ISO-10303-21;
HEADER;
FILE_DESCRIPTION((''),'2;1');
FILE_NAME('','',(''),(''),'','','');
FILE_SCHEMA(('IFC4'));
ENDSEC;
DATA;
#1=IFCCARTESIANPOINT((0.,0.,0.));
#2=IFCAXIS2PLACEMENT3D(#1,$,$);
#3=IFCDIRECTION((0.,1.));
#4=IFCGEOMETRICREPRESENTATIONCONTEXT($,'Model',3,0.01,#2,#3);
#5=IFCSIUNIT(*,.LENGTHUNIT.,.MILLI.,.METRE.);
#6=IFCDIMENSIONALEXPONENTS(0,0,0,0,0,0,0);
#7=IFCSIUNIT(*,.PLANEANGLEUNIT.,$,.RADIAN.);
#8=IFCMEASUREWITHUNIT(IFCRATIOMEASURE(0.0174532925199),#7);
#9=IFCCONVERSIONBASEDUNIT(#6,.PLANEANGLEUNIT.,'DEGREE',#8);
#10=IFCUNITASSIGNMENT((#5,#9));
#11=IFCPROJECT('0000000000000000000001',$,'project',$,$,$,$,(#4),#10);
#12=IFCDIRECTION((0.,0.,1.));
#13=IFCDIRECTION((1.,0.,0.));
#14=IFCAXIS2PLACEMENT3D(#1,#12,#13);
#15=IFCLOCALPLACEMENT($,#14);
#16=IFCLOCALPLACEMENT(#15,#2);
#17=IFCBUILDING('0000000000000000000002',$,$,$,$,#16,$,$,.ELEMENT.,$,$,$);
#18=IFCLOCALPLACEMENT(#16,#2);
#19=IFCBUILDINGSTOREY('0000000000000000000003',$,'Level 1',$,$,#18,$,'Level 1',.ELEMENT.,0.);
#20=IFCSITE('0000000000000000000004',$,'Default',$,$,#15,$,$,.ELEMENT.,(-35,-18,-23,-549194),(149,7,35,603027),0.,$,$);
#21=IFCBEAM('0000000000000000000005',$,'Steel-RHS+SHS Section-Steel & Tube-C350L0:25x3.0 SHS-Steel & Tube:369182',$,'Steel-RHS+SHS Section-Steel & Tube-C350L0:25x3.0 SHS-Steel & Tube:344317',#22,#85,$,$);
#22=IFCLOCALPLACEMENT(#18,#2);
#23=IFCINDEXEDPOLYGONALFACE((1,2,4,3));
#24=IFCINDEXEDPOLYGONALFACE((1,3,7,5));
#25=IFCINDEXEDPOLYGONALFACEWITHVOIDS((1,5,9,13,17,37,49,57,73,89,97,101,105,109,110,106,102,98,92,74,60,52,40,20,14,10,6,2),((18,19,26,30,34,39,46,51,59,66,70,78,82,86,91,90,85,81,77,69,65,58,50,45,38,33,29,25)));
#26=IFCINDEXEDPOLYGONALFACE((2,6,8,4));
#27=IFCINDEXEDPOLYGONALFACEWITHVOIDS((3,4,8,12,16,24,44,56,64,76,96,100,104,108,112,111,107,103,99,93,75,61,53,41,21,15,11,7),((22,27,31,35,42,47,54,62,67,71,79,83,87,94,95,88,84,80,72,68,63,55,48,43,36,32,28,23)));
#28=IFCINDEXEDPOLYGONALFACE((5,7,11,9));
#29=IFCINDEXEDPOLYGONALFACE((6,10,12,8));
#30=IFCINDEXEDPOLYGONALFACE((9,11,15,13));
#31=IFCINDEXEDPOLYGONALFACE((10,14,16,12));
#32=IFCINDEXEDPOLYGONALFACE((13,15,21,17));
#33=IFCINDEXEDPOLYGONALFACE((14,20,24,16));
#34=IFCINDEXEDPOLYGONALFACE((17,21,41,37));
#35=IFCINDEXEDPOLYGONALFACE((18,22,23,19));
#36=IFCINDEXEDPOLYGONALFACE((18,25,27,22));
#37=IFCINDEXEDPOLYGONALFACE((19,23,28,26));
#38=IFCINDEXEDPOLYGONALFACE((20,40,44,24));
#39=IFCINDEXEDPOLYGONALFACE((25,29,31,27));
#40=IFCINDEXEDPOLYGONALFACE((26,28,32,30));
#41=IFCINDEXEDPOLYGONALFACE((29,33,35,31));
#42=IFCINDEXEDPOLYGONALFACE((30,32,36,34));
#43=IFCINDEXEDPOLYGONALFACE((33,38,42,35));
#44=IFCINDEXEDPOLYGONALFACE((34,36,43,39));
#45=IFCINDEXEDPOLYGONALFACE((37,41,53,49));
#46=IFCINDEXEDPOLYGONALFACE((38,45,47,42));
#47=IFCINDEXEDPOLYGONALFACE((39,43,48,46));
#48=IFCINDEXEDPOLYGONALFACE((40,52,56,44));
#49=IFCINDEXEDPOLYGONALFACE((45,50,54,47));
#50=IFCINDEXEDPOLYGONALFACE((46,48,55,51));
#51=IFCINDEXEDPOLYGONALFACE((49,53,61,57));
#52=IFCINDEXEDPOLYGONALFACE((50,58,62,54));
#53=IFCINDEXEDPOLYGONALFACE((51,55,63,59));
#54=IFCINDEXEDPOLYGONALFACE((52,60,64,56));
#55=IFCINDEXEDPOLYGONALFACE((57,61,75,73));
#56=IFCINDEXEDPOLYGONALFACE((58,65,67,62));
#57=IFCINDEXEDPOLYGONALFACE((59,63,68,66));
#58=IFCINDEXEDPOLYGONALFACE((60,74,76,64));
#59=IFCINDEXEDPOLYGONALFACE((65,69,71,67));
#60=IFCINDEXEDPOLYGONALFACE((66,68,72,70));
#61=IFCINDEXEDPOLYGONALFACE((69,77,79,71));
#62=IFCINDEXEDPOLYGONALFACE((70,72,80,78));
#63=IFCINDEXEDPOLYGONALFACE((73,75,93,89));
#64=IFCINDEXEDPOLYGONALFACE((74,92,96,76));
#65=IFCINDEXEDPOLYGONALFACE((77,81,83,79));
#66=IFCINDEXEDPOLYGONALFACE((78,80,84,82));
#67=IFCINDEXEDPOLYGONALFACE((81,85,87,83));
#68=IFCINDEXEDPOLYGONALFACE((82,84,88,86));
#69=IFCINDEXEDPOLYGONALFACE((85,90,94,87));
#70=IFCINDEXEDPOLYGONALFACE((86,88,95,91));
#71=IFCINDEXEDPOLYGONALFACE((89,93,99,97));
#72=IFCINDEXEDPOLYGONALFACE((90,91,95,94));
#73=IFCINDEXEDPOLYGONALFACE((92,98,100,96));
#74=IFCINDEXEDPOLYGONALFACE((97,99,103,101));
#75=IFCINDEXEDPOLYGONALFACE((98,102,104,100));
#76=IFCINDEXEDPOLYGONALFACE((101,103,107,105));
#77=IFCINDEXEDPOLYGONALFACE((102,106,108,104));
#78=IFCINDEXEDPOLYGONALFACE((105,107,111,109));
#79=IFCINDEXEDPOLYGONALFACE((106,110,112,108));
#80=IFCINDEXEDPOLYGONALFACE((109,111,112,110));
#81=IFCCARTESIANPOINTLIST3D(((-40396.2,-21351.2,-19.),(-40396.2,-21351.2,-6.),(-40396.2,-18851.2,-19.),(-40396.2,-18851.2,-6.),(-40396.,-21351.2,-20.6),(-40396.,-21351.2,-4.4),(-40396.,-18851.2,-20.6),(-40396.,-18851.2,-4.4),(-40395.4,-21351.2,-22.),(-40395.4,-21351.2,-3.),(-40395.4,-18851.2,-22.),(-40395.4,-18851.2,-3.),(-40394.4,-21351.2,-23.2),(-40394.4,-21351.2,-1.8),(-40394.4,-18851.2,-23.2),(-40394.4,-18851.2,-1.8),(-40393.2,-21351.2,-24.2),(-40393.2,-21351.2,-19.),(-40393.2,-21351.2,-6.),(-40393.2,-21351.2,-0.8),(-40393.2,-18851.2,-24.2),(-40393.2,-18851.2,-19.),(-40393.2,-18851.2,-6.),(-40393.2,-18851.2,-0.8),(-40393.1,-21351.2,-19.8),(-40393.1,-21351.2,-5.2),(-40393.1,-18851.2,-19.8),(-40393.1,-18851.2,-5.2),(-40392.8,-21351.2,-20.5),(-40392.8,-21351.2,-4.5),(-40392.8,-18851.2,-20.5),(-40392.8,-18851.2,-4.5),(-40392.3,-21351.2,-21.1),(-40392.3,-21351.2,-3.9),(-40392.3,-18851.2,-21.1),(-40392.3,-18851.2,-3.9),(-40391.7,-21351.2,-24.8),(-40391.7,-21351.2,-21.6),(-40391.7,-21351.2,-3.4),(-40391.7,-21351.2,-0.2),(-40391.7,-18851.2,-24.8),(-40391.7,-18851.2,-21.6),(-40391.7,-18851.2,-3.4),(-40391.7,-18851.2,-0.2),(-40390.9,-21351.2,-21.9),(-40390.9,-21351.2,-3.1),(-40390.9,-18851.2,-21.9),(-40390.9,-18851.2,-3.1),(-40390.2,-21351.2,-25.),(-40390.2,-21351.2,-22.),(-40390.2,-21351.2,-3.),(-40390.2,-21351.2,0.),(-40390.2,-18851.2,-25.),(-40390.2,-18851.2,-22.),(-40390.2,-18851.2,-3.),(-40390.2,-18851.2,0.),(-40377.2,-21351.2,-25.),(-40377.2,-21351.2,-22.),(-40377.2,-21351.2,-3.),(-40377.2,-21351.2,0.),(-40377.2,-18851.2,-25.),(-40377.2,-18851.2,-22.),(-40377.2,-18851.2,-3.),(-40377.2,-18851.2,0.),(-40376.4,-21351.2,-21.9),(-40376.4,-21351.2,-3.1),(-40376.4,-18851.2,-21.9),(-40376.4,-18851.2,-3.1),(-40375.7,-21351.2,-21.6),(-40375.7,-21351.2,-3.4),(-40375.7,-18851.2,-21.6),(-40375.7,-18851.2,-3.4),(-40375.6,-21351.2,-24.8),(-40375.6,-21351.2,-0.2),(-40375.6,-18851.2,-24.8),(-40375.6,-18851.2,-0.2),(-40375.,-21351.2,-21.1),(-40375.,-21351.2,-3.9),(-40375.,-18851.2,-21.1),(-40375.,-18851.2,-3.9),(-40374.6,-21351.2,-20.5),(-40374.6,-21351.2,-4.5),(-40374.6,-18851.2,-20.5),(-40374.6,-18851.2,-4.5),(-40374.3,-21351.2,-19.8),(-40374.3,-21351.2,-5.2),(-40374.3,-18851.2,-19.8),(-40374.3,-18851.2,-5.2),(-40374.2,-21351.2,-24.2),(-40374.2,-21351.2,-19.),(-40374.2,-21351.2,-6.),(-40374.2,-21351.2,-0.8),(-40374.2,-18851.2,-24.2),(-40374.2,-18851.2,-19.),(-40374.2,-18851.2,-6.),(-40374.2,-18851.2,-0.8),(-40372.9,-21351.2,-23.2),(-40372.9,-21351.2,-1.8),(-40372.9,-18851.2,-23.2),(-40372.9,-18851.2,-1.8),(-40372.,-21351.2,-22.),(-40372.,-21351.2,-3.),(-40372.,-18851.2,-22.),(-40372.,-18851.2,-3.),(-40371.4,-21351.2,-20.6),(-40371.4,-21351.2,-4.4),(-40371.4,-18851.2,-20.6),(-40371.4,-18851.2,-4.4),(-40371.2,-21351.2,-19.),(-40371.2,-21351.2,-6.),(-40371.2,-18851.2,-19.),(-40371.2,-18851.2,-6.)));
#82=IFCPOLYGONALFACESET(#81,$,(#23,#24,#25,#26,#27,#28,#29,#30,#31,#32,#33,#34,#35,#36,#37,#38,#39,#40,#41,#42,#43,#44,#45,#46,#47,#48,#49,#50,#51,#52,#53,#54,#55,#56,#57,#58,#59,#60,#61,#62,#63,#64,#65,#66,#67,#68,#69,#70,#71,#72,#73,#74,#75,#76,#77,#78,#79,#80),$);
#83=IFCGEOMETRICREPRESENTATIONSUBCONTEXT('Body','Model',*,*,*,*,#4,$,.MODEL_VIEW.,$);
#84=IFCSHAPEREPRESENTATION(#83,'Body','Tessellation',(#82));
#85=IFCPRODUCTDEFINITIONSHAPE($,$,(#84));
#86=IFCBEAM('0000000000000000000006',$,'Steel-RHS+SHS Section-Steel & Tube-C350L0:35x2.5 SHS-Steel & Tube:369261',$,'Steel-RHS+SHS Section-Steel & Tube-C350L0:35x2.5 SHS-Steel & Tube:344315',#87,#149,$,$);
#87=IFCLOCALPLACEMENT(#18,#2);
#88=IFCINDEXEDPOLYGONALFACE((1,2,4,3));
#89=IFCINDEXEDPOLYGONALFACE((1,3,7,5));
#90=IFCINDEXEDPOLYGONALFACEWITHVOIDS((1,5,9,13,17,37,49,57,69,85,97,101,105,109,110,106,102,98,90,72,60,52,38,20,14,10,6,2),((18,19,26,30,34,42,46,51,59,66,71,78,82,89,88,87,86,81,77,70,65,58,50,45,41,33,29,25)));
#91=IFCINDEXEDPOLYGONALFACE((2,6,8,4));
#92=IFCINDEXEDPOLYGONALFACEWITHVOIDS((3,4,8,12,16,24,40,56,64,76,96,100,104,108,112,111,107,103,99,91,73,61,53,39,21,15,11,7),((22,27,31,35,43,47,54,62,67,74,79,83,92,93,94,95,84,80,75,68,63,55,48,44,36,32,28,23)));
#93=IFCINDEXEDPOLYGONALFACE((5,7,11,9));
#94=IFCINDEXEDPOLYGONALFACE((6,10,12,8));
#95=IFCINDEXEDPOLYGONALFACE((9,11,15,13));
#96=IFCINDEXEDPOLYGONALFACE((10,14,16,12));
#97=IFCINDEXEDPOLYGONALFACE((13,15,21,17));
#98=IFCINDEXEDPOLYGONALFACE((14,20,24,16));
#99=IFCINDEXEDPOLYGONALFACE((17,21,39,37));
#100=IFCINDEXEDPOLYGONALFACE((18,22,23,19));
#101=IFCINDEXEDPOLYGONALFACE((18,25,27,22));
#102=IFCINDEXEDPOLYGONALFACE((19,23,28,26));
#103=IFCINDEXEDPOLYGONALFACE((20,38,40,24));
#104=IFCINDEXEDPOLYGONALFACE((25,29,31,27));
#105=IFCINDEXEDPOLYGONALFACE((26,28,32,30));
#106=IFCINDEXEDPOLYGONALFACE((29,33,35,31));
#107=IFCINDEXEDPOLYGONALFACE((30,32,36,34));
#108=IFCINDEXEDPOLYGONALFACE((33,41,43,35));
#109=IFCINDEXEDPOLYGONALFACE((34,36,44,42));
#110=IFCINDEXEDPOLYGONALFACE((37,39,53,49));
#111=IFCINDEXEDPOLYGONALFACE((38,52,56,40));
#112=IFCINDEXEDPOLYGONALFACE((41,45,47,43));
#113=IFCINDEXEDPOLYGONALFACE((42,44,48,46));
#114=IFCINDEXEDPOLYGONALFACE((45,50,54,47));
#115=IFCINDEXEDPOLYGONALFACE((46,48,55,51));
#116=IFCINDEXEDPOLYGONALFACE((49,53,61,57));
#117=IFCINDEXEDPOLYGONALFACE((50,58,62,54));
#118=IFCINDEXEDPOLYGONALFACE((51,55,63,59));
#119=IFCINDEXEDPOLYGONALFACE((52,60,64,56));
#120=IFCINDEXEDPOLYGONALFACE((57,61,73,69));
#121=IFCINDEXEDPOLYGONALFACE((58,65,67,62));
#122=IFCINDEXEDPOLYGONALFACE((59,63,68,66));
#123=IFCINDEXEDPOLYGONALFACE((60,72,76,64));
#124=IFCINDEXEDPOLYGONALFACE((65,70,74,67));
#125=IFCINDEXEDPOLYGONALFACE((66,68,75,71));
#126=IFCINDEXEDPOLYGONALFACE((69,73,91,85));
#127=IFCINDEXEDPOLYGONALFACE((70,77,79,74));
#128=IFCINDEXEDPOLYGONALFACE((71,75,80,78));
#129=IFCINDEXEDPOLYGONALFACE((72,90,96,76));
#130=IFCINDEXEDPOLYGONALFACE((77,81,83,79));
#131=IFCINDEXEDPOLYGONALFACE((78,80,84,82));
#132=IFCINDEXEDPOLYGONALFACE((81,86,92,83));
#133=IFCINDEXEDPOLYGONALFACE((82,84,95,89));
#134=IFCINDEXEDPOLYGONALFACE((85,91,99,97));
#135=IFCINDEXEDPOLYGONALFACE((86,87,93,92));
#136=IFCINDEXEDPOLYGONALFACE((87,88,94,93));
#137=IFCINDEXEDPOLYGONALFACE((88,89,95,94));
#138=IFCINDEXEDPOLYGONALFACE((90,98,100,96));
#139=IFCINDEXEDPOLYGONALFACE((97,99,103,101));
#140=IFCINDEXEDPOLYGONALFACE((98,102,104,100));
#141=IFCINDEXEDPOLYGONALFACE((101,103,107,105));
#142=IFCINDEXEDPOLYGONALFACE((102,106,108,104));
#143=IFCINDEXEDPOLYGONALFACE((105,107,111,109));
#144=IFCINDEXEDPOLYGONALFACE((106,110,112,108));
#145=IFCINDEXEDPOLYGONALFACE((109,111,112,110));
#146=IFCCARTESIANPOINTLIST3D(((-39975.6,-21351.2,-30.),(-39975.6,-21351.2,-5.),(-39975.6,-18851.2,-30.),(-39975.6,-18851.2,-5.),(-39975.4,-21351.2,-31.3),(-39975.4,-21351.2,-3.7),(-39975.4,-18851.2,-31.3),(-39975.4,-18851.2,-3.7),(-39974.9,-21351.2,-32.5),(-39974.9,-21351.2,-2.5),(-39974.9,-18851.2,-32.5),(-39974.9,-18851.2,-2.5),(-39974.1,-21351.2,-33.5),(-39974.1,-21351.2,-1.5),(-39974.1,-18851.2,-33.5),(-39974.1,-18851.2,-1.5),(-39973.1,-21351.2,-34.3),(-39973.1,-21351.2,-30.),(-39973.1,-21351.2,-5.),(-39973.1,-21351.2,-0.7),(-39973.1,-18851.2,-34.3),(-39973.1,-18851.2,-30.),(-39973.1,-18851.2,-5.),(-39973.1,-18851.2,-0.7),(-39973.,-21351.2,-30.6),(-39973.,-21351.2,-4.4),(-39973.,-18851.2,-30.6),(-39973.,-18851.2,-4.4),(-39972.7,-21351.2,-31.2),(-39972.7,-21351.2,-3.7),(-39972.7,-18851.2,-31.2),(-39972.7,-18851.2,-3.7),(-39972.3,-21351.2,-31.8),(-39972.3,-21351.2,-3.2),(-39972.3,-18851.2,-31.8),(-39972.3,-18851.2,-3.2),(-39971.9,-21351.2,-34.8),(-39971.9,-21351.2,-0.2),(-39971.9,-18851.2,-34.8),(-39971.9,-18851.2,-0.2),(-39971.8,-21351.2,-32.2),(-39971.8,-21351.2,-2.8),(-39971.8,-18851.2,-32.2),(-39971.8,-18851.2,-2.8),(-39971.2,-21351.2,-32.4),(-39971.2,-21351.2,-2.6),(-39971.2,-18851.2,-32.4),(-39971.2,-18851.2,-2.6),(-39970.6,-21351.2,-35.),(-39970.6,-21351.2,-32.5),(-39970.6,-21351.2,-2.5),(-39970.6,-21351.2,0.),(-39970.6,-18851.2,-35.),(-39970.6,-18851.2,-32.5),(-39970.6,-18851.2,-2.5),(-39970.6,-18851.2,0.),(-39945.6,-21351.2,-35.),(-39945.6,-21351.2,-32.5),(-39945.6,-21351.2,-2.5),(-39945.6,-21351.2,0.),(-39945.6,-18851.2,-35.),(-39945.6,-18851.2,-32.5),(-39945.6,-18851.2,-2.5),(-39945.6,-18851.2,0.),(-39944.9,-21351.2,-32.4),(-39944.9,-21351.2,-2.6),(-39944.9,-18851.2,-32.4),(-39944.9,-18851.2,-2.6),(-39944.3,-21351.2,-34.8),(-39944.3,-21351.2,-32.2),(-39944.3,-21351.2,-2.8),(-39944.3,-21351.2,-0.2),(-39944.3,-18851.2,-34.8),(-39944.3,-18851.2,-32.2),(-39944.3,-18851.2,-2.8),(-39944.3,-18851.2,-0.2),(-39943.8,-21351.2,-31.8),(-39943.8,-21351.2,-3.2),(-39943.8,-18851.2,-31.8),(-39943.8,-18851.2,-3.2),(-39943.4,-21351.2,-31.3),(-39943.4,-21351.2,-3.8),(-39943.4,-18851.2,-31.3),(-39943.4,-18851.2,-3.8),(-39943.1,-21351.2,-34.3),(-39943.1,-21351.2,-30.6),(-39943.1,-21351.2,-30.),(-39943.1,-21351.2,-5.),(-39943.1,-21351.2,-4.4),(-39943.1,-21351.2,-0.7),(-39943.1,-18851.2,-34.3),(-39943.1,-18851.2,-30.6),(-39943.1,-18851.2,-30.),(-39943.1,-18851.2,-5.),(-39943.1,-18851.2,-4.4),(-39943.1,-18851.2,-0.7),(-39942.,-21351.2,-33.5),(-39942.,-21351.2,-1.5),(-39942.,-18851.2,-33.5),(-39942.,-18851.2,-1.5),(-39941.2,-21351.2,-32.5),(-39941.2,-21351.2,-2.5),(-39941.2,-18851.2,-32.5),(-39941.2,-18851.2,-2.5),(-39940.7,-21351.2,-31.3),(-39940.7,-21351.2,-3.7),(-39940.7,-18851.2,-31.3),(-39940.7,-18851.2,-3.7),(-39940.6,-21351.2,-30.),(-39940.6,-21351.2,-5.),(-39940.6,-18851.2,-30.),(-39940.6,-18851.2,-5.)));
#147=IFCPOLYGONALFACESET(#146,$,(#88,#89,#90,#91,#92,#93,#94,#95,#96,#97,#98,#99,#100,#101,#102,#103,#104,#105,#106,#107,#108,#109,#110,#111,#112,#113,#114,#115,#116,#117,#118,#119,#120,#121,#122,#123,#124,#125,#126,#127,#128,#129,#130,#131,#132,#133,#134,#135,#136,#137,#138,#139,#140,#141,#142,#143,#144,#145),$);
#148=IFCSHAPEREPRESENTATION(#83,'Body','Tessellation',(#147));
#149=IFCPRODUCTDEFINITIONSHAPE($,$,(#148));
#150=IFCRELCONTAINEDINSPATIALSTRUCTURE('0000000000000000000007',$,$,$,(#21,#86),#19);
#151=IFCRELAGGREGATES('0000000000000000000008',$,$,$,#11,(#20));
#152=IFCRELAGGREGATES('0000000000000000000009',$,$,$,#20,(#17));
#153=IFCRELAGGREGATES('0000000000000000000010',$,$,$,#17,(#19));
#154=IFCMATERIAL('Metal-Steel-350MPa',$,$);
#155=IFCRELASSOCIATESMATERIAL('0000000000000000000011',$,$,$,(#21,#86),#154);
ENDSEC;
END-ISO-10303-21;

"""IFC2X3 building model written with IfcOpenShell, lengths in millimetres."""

from ifc_helpers import new_model, entity, si_unit, converted_unit, direction, frame, frame_2d, origin, origin_with_axes, place, context, subcontext, project, spatial, polyline, circle_curve, parameter, trimmed, segment, composite_curve, outline, extrude, material, element, save


model = new_model("IFC2X3")

# Units and contexts
model_context = context("Model", 3, precision=0.01, world=origin(), true_north=direction((0.0, 1.0)))
body_context = subcontext(model_context, "Body", "Model", "MODEL_VIEW")
ifc_project = project(units=[si_unit("LENGTHUNIT", "METRE", prefix="MILLI"), converted_unit("PLANEANGLEUNIT", "DEGREE", entity("IfcRatioMeasure", 0.0174532925199), si_unit("PLANEANGLEUNIT", "RADIAN"), dimensions=[0, 0, 0, 0, 0, 0, 0])], contexts=[model_context])

# Site, building, storey
site_placement = place(None, origin_with_axes())
site = spatial("IfcSite", under=ifc_project, at=site_placement, Name="Default", CompositionType="ELEMENT", RefLatitude=(-35, -18, -23, -549194), RefLongitude=(149, 7, 35, 603027), RefElevation=0.0)
building_placement = place(site_placement, origin())
building = spatial("IfcBuilding", under=site, at=building_placement, CompositionType="ELEMENT")
storey_placement = place(building_placement, origin())
storey = spatial("IfcBuildingStorey", under=building, at=storey_placement, Name="Level 1", LongName="Level 1", CompositionType="ELEMENT", Elevation=0.0)

# Beams
ifc_material = material(Name="Metal-Steel-350MPa")
beam_1_placement = place(storey_placement, frame((-40383.7, -18851.2, 0.0), z_axis=(0.0, 0.0, 1.0), x_axis=(0.0, -1.0, 0.0)))
element("IfcBeam", 1, at=beam_1_placement, inside=storey, material=ifc_material, Name="Steel-RHS+SHS Section-Steel & Tube-C350L0:25x3.0 SHS-Steel & Tube:369182", ObjectType="Steel-RHS+SHS Section-Steel & Tube-C350L0:25x3.0 SHS-Steel & Tube:344317", context=body_context, shape_type="SweptSolid", body=[
    extrude(outline(composite_curve([segment(trimmed(circle_curve(frame_2d((-6.5, -6.5), x_axis=(1.0, 0.0)), 6.0), [parameter(180.0)], [parameter(270.0)], True, "PARAMETER"), True, "CONTINUOUS"), segment(polyline([(-6.5, -12.5), (6.5, -12.5)]), True, "CONTINUOUS"), segment(trimmed(circle_curve(frame_2d((6.5, -6.5), x_axis=(1.0, 0.0)), 6.0), [parameter(270.0)], [parameter(0.0)], True, "PARAMETER"), True, "CONTINUOUS"), segment(polyline([(12.5, -6.5), (12.5, 6.5)]), True, "CONTINUOUS"), segment(trimmed(circle_curve(frame_2d((6.5, 6.5), x_axis=(1.0, 0.0)), 6.0), [parameter(0.0)], [parameter(90.0)], True, "PARAMETER"), True, "CONTINUOUS"), segment(polyline([(6.5, 12.5), (-6.5, 12.5)]), True, "CONTINUOUS"), segment(trimmed(circle_curve(frame_2d((-6.5, 6.5), x_axis=(1.0, 0.0)), 6.0), [parameter(90.0)], [parameter(180.0)], True, "PARAMETER"), True, "CONTINUOUS"), segment(polyline([(-12.5, 6.5), (-12.5, -6.5)]), True, "CONTINUOUS")], self_intersect=False), holes=[composite_curve([segment(polyline([(6.5, -9.5), (-6.5, -9.5)]), True, "CONTINUOUS"), segment(trimmed(circle_curve(frame_2d((-6.5, -6.5), x_axis=(1.0, 0.0)), 3.0), [parameter(180.0)], [parameter(270.0)], True, "PARAMETER"), False, "CONTINUOUS"), segment(polyline([(-9.5, -6.5), (-9.5, 6.5)]), True, "CONTINUOUS"), segment(trimmed(circle_curve(frame_2d((-6.5, 6.5), x_axis=(1.0, 0.0)), 3.0), [parameter(90.0)], [parameter(180.0)], True, "PARAMETER"), False, "CONTINUOUS"), segment(polyline([(-6.5, 9.5), (6.5, 9.5)]), True, "CONTINUOUS"), segment(trimmed(circle_curve(frame_2d((6.5, 6.5), x_axis=(1.0, 0.0)), 3.0), [parameter(360.0)], [parameter(90.0)], True, "PARAMETER"), False, "CONTINUOUS"), segment(polyline([(9.5, 6.5), (9.5, -6.5)]), True, "CONTINUOUS"), segment(trimmed(circle_curve(frame_2d((6.5, -6.5), x_axis=(1.0, 0.0)), 3.0), [parameter(270.0)], [parameter(0.0)], True, "PARAMETER"), False, "CONTINUOUS")], self_intersect=False)]), frame((0.0, 0.0, -12.5), z_axis=(1.0, 0.0, 0.0), x_axis=(0.0, -1.0, 0.0)), (0.0, 0.0, 1.0), 2500.0),
])
beam_2_placement = place(storey_placement, frame((-39958.1, -18851.2, 0.0), z_axis=(0.0, 0.0, 1.0), x_axis=(0.0, -1.0, 0.0)))
element("IfcBeam", 2, at=beam_2_placement, inside=storey, material=ifc_material, Name="Steel-RHS+SHS Section-Steel & Tube-C350L0:35x2.5 SHS-Steel & Tube:369261", ObjectType="Steel-RHS+SHS Section-Steel & Tube-C350L0:35x2.5 SHS-Steel & Tube:344315", context=body_context, shape_type="SweptSolid", body=[
    extrude(outline(composite_curve([segment(trimmed(circle_curve(frame_2d((-12.5, -12.5), x_axis=(1.0, 0.0)), 5.0), [parameter(180.0)], [parameter(270.0)], True, "PARAMETER"), True, "CONTINUOUS"), segment(polyline([(-12.5, -17.5), (12.5, -17.5)]), True, "CONTINUOUS"), segment(trimmed(circle_curve(frame_2d((12.5, -12.5), x_axis=(1.0, 0.0)), 5.0), [parameter(270.0)], [parameter(0.0)], True, "PARAMETER"), True, "CONTINUOUS"), segment(polyline([(17.5, -12.5), (17.5, 12.5)]), True, "CONTINUOUS"), segment(trimmed(circle_curve(frame_2d((12.5, 12.5), x_axis=(1.0, 0.0)), 5.0), [parameter(0.0)], [parameter(90.0)], True, "PARAMETER"), True, "CONTINUOUS"), segment(polyline([(12.5, 17.5), (-12.5, 17.5)]), True, "CONTINUOUS"), segment(trimmed(circle_curve(frame_2d((-12.5, 12.5), x_axis=(1.0, 0.0)), 5.0), [parameter(90.0)], [parameter(180.0)], True, "PARAMETER"), True, "CONTINUOUS"), segment(polyline([(-17.5, 12.5), (-17.5, -12.5)]), True, "CONTINUOUS")], self_intersect=False), holes=[composite_curve([segment(polyline([(12.5, -15.0), (-12.5, -15.0)]), True, "CONTINUOUS"), segment(trimmed(circle_curve(frame_2d((-12.5, -12.5), x_axis=(1.0, 0.0)), 2.5), [parameter(180.0)], [parameter(270.0)], True, "PARAMETER"), False, "CONTINUOUS"), segment(polyline([(-15.0, -12.5), (-15.0, 12.5)]), True, "CONTINUOUS"), segment(trimmed(circle_curve(frame_2d((-12.5, 12.5), x_axis=(1.0, 0.0)), 2.5), [parameter(90.0)], [parameter(180.0)], True, "PARAMETER"), False, "CONTINUOUS"), segment(polyline([(-12.5, 15.0), (12.5, 15.0)]), True, "CONTINUOUS"), segment(trimmed(circle_curve(frame_2d((12.5, 12.5), x_axis=(1.0, 0.0)), 2.5), [parameter(360.0)], [parameter(90.0)], True, "PARAMETER"), False, "CONTINUOUS"), segment(polyline([(15.0, 12.5), (15.0, -12.5)]), True, "CONTINUOUS"), segment(trimmed(circle_curve(frame_2d((12.5, -12.5), x_axis=(1.0, 0.0)), 2.5), [parameter(270.0)], [parameter(360.0)], True, "PARAMETER"), False, "CONTINUOUS")], self_intersect=False)]), frame((0.0, 0.0, -17.5), z_axis=(1.0, 0.0, 0.0), x_axis=(0.0, -1.0, 0.0)), (0.0, 0.0, 1.0), 2500.0),
])

save(model, "model.ifc")
